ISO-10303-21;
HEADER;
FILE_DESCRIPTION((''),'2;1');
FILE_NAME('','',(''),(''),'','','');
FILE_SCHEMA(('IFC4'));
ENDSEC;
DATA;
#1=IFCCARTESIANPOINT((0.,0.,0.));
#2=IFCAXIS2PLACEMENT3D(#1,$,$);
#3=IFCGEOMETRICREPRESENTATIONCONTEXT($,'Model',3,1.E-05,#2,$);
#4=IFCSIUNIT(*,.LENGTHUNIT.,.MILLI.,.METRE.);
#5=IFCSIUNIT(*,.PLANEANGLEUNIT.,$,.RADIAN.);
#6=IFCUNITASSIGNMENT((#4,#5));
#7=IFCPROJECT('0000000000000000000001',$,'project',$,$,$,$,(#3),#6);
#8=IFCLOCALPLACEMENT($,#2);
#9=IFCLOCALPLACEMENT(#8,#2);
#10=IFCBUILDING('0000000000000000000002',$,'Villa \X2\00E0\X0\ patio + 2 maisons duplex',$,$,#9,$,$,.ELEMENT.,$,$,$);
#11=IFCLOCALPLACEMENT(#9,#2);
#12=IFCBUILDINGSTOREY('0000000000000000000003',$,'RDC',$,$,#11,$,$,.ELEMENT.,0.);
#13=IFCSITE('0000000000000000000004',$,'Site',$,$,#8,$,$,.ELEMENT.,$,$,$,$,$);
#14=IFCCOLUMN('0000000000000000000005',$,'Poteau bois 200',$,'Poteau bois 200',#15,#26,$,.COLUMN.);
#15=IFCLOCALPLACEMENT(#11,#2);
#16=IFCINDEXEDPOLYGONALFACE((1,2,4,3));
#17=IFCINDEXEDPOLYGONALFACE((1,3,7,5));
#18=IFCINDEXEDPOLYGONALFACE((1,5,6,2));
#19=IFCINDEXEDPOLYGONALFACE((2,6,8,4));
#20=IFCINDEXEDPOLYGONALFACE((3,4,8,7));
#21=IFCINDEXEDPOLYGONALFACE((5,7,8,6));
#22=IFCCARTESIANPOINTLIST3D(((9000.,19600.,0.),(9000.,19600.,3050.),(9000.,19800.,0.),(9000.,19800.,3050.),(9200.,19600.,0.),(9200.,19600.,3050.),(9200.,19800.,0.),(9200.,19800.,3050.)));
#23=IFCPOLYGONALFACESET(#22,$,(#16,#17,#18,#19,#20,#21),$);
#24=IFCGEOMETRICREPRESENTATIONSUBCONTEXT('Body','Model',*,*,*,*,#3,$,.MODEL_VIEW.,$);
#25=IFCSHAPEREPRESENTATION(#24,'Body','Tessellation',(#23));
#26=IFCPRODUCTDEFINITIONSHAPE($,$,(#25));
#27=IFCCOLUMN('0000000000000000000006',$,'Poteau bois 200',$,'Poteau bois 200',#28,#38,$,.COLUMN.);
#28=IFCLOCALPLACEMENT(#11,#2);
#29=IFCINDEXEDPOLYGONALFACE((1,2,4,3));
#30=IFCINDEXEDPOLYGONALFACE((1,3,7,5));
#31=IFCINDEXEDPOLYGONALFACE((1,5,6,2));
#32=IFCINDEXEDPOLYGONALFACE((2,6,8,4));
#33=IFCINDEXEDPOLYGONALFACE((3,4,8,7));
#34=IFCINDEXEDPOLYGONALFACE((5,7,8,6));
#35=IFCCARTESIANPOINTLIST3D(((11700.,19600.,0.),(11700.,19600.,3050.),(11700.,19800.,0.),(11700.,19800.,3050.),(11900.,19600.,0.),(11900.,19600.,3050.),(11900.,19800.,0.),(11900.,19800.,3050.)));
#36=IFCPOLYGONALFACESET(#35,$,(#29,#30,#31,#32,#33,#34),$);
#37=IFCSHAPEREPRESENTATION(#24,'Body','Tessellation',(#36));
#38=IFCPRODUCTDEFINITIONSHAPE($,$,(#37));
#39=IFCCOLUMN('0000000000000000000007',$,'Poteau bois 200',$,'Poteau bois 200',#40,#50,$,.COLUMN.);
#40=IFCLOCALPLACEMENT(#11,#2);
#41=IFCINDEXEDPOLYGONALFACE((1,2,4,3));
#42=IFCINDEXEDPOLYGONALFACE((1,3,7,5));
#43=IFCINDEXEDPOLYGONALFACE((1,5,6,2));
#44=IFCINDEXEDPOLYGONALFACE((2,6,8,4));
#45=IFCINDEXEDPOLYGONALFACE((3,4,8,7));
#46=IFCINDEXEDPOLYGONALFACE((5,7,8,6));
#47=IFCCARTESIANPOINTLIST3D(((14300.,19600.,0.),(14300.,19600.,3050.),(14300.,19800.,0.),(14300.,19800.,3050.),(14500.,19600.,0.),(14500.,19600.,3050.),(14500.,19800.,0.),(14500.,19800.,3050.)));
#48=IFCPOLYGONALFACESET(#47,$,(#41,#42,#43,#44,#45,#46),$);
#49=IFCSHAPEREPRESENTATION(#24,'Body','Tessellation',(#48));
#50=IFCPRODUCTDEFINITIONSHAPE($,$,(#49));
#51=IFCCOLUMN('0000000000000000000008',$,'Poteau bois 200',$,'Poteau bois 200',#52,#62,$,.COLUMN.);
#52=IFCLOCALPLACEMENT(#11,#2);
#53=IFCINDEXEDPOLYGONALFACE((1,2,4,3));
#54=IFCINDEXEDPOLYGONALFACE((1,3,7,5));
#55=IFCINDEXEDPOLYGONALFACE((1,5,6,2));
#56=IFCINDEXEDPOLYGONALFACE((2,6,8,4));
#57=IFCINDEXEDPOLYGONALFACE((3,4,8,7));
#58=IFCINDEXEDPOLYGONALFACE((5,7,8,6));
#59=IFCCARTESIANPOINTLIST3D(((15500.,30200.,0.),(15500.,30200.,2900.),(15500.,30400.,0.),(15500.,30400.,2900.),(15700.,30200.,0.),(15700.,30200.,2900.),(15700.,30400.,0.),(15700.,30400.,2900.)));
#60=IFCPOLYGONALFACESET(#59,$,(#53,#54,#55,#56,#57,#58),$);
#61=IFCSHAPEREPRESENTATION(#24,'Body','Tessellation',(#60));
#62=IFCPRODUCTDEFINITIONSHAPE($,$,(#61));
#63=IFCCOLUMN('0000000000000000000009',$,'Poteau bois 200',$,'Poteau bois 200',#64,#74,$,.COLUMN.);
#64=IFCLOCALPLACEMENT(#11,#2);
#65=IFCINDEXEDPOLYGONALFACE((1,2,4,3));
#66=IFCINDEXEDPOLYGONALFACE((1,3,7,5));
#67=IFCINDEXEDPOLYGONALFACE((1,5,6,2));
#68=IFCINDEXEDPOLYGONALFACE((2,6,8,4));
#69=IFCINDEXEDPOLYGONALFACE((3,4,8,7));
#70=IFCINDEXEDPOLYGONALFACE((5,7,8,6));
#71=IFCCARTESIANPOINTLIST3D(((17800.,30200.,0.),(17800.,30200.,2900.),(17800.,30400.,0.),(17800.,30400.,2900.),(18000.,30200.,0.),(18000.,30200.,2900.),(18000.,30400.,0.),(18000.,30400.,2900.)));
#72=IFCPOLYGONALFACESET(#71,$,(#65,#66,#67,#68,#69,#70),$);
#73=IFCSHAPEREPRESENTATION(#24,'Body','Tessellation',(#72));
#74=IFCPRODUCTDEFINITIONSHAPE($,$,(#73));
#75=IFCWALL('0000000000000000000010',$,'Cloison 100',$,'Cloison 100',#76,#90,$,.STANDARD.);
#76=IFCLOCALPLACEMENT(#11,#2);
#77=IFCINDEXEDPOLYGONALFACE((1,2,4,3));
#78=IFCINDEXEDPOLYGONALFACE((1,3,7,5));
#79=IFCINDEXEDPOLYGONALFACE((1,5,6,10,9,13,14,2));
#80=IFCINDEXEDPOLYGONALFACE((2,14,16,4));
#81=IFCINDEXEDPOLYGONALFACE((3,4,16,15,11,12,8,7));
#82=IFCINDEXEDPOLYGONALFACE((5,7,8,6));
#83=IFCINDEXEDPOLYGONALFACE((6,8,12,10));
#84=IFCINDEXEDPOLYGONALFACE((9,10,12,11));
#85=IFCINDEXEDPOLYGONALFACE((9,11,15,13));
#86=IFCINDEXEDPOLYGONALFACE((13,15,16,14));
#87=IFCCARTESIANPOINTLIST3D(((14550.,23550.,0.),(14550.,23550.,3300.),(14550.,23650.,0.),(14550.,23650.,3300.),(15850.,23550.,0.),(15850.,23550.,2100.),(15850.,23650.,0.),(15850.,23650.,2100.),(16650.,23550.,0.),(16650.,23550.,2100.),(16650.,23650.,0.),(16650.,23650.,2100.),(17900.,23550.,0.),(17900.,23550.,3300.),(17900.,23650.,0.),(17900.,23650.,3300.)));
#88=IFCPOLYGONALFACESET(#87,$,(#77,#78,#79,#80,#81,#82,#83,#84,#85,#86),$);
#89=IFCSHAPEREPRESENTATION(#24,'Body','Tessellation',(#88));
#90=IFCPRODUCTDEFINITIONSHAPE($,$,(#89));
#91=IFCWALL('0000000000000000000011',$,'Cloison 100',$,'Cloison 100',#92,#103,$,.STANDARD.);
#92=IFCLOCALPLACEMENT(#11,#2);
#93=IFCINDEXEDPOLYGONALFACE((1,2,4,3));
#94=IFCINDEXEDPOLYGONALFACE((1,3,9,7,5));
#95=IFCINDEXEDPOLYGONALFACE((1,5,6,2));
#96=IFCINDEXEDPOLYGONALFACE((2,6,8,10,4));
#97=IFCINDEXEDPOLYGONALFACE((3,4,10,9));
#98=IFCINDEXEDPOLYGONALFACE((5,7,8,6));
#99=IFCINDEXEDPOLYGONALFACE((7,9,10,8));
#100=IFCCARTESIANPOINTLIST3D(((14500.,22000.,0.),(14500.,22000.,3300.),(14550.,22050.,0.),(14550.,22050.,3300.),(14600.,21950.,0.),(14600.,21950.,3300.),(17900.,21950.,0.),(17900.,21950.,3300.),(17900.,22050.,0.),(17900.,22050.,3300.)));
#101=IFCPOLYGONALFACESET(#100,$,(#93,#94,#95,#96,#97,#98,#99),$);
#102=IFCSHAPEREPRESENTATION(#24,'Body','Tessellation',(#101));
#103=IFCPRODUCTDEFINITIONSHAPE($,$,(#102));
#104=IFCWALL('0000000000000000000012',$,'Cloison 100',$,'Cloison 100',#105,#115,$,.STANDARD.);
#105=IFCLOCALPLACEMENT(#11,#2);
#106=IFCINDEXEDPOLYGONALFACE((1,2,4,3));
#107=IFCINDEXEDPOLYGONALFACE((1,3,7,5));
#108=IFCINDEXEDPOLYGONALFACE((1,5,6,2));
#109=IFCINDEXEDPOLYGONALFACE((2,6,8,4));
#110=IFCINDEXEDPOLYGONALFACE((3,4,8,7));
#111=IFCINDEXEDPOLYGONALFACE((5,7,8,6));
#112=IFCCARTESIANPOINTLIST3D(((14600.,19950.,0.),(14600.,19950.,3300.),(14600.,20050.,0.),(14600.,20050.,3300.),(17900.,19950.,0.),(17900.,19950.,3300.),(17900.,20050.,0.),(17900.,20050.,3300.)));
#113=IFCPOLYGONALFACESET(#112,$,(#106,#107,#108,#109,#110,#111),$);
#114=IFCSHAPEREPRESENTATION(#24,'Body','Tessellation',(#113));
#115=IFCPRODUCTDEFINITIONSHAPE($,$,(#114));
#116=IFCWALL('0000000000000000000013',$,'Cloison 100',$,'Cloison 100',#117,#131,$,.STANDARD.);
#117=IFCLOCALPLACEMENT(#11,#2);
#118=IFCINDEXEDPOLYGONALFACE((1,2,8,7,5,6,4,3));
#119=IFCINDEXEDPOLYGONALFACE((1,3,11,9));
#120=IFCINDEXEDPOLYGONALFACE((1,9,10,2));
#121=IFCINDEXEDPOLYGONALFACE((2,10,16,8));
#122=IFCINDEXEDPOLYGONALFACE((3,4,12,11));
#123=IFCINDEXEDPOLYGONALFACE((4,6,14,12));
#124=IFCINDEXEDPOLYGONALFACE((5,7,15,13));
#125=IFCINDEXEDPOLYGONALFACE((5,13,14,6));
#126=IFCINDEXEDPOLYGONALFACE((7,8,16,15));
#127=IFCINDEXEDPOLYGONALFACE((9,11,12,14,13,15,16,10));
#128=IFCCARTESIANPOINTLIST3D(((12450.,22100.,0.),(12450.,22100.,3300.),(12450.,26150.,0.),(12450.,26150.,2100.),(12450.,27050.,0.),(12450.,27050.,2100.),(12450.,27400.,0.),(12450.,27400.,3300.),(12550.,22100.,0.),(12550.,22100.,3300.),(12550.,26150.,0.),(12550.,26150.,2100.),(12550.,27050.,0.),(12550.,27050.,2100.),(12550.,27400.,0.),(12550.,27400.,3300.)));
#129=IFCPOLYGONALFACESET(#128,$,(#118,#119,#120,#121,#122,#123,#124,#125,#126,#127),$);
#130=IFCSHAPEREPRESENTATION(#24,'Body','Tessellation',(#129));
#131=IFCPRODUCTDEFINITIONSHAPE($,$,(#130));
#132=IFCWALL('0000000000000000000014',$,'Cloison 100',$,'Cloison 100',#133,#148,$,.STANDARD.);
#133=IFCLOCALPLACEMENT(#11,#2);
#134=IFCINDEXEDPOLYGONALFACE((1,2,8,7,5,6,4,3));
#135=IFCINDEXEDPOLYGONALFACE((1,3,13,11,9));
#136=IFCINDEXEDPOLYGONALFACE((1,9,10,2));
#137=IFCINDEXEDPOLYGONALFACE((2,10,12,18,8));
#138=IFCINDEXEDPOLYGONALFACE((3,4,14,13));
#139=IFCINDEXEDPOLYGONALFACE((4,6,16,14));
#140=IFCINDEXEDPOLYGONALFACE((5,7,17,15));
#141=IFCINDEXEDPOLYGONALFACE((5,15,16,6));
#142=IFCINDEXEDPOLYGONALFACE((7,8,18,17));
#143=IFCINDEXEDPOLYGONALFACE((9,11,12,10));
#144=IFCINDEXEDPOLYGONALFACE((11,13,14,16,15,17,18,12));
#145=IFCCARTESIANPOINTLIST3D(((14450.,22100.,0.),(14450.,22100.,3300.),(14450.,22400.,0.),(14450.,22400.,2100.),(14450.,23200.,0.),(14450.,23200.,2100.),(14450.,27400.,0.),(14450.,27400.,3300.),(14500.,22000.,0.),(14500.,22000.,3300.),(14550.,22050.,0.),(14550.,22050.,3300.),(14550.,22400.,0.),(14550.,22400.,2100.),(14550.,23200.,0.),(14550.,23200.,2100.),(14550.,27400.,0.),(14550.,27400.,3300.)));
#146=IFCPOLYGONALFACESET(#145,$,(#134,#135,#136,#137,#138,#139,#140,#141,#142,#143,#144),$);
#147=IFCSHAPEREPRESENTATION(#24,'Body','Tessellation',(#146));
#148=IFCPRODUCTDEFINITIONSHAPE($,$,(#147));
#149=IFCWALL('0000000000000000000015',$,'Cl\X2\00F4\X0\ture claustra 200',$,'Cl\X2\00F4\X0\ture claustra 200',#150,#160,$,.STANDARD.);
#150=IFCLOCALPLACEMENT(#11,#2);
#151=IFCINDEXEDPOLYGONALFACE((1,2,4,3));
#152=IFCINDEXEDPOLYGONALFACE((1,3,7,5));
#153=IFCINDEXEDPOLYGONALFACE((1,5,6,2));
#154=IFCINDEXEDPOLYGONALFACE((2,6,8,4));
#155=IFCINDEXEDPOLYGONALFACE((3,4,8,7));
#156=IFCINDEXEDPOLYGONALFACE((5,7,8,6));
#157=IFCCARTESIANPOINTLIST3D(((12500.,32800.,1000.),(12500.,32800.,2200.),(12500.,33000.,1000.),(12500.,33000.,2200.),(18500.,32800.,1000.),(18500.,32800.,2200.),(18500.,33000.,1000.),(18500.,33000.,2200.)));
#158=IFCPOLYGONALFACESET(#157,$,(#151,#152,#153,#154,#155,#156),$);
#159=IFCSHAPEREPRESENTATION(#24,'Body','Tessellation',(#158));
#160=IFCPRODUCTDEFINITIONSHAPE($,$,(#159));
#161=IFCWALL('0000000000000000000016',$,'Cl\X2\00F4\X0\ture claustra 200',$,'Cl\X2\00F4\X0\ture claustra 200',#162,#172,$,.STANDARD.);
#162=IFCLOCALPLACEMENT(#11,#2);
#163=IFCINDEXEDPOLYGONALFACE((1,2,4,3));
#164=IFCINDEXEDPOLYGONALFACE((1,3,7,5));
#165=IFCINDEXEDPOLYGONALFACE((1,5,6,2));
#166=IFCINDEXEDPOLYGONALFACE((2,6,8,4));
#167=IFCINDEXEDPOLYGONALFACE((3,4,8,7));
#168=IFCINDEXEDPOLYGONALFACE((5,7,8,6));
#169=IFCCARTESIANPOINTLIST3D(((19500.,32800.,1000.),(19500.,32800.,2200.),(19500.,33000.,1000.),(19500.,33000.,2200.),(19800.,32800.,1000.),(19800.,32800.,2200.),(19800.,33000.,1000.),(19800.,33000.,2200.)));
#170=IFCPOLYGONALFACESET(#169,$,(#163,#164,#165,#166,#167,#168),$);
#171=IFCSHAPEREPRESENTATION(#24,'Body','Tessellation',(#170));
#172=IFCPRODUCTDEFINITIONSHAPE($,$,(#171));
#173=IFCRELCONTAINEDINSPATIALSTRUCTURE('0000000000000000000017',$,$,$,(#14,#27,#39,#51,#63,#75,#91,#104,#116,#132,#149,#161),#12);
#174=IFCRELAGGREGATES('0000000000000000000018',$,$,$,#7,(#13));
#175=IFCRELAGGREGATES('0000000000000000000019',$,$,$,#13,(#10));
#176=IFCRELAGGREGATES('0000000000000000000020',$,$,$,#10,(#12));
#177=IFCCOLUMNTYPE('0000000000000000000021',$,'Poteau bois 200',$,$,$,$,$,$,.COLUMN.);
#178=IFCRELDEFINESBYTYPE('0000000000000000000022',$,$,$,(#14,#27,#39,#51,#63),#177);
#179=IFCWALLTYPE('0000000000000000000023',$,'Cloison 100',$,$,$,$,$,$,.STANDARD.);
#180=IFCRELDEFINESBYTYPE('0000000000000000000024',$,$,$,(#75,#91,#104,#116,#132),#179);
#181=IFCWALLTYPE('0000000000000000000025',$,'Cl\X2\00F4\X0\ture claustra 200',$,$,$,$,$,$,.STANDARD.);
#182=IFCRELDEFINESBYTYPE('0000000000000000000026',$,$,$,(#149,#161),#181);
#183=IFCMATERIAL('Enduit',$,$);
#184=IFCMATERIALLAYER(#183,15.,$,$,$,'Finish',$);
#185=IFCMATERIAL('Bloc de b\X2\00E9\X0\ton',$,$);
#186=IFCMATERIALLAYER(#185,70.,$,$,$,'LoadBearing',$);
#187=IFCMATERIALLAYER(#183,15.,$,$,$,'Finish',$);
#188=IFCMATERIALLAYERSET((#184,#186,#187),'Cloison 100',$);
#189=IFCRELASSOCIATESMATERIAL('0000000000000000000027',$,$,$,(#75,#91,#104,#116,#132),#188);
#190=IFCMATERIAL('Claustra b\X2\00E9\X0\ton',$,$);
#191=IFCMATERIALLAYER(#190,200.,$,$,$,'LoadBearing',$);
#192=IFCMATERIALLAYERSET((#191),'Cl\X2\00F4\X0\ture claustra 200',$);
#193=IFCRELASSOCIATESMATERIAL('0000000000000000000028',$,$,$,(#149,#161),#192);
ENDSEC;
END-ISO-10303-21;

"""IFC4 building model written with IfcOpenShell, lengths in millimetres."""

from ifc_helpers import new_model, si_unit, frame, frame_2d, origin, origin_2d, place, context, subcontext, project, spatial, polyline, rectangle, outline, extrude, material, layer, layer_set, layer_usage, material_profile, profile_set, profile_usage, type_object, element, save


model = new_model("IFC4")

# Units and contexts
model_context = context("Model", 3, precision=1e-05, world=origin())
body_context = subcontext(model_context, "Body", "Model", "MODEL_VIEW")
ifc_project = project(units=[si_unit("LENGTHUNIT", "METRE", prefix="MILLI"), si_unit("PLANEANGLEUNIT", "RADIAN")], contexts=[model_context])

# Site, building, storey
site_placement = place(None, origin())
site = spatial("IfcSite", under=ifc_project, at=site_placement, Name="Site", CompositionType="ELEMENT")
building_placement = place(site_placement, origin())
building = spatial("IfcBuilding", under=site, at=building_placement, Name="Villa à patio + 2 maisons duplex", CompositionType="ELEMENT")
storey_placement = place(building_placement, origin())
storey = spatial("IfcBuildingStorey", under=building, at=storey_placement, Name="RDC", CompositionType="ELEMENT", Elevation=0.0)

# Columns
ifc_material_profile = material_profile(None, rectangle(XDim=200.0, YDim=200.0, at=origin_2d()), Name="Poteau bois 200")
ifc_profile_set = profile_set([ifc_material_profile], Name="Poteau bois 200")
ifc_profile_usage = profile_usage(ifc_profile_set, cardinal=5)
column_type = type_object("IfcColumnType", Name="Poteau bois 200", PredefinedType="COLUMN", material=ifc_profile_set)
for number, where, z_axis, x_axis, name in (
    (1, (9100.0, 19700.0, 0.0), (0.0, 0.0, 1.0), (1.0, 0.0, 0.0), "Poteau bois 200"),
    (2, (11800.0, 19700.0, 0.0), (0.0, 0.0, 1.0), (1.0, 0.0, 0.0), "Poteau bois 200"),
    (3, (14400.0, 19700.0, 0.0), (0.0, 0.0, 1.0), (1.0, 0.0, 0.0), "Poteau bois 200"),
):
    element("IfcColumn", number, at=place(storey_placement, frame(where, z_axis=z_axis, x_axis=x_axis)), inside=storey, type_object=column_type, material=ifc_profile_usage, Name=name, ObjectType="Poteau bois 200", PredefinedType="COLUMN", context=body_context, shape_type="SweptSolid", body=[
        extrude(rectangle(XDim=200.0, YDim=200.0, at=origin_2d()), origin(), (0.0, 0.0, 1.0), 3050.0),
    ])
for number, where, z_axis, x_axis, name in (
    (4, (15600.0, 30300.0, 0.0), (0.0, 0.0, 1.0), (1.0, 0.0, 0.0), "Poteau bois 200"),
    (5, (17900.0, 30300.0, 0.0), (0.0, 0.0, 1.0), (1.0, 0.0, 0.0), "Poteau bois 200"),
):
    element("IfcColumn", number, at=place(storey_placement, frame(where, z_axis=z_axis, x_axis=x_axis)), inside=storey, type_object=column_type, material=ifc_profile_usage, Name=name, ObjectType="Poteau bois 200", PredefinedType="COLUMN", context=body_context, shape_type="SweptSolid", body=[
        extrude(rectangle(XDim=200.0, YDim=200.0, at=origin_2d()), origin(), (0.0, 0.0, 1.0), 2900.0),
    ])

# Wall, opening
ifc_material_1 = material(Name="Enduit")
ifc_layer_1 = layer(ifc_material_1, 15.0, Category="Finish")
ifc_material_2 = material(Name="Bloc de béton")
ifc_layer_2 = layer(ifc_material_2, 70.0, Category="LoadBearing")
ifc_layer_3 = layer(ifc_material_1, 15.0, Category="Finish")
ifc_layer_set_1 = layer_set([ifc_layer_1, ifc_layer_2, ifc_layer_3], Name="Cloison 100")
ifc_layer_usage_1 = layer_usage(ifc_layer_set_1, "AXIS2", "NEGATIVE", 50.0)
wall_type_1 = type_object("IfcWallType", Name="Cloison 100", PredefinedType="STANDARD")
wall_1_placement = place(storey_placement, frame((14500.0, 23600.0, 0.0), z_axis=(0.0, 0.0, 1.0), x_axis=(1.0, 0.0, 0.0)))
wall_1 = element("IfcWall", 6, at=wall_1_placement, inside=storey, type_object=wall_type_1, material=ifc_layer_usage_1, Name="Cloison 100", ObjectType="Cloison 100", PredefinedType="STANDARD", context=body_context, shape_type="SweptSolid", body=[
    extrude(outline(polyline([(50.0, -50.0), (50.0, 50.0), (3400.0, 50.0), (3400.0, -50.0), (50.0, -50.0)])), origin(), (0.0, 0.0, 1.0), 3300.0),
])
opening_1_placement = place(wall_1_placement, frame((1350.0, 0.0, 0.0), z_axis=(0.0, 0.0, 1.0), x_axis=(1.0, 0.0, 0.0)))
element("IfcOpeningElement", 7, at=opening_1_placement, cuts=wall_1, PredefinedType="OPENING", context=body_context, shape_type="SweptSolid", body=[
    extrude(rectangle(XDim=800.0, YDim=120.0, at=frame_2d((400.0, 0.0))), origin(), (0.0, 0.0, 1.0), 2100.0),
])

# Walls
wall_2_placement = place(storey_placement, frame((14500.0, 22000.0, 0.0), z_axis=(0.0, 0.0, 1.0), x_axis=(1.0, 0.0, 0.0)))
element("IfcWall", 8, at=wall_2_placement, inside=storey, type_object=wall_type_1, material=ifc_layer_usage_1, Name="Cloison 100", ObjectType="Cloison 100", PredefinedType="STANDARD", context=body_context, shape_type="SweptSolid", body=[
    extrude(outline(polyline([(100.0, -50.0), (0.0, 0.0), (50.0, 50.0), (3400.0, 50.0), (3400.0, -50.0), (100.0, -50.0)])), origin(), (0.0, 0.0, 1.0), 3300.0),
])
wall_3_placement = place(storey_placement, frame((14500.0, 20000.0, 0.0), z_axis=(0.0, 0.0, 1.0), x_axis=(1.0, 0.0, 0.0)))
element("IfcWall", 9, at=wall_3_placement, inside=storey, type_object=wall_type_1, material=ifc_layer_usage_1, Name="Cloison 100", ObjectType="Cloison 100", PredefinedType="STANDARD", context=body_context, shape_type="SweptSolid", body=[
    extrude(outline(polyline([(100.0, -50.0), (100.0, 50.0), (3400.0, 50.0), (3400.0, -50.0), (100.0, -50.0)])), origin(), (0.0, 0.0, 1.0), 3300.0),
])

# Walls, openings
wall_4_placement = place(storey_placement, frame((12500.0, 27500.0, 0.0), z_axis=(0.0, 0.0, 1.0), x_axis=(0.0, -1.0, 0.0)))
wall_4 = element("IfcWall", 10, at=wall_4_placement, inside=storey, type_object=wall_type_1, material=ifc_layer_usage_1, Name="Cloison 100", ObjectType="Cloison 100", PredefinedType="STANDARD", context=body_context, shape_type="SweptSolid", body=[
    extrude(outline(polyline([(100.0, -50.0), (100.0, 50.0), (5400.0, 50.0), (5400.0, -50.0), (100.0, -50.0)])), origin(), (0.0, 0.0, 1.0), 3300.0),
])
opening_2_placement = place(wall_4_placement, frame((450.0, 0.0, 0.0), z_axis=(0.0, 0.0, 1.0), x_axis=(1.0, 0.0, 0.0)))
element("IfcOpeningElement", 11, at=opening_2_placement, cuts=wall_4, PredefinedType="OPENING", context=body_context, shape_type="SweptSolid", body=[
    extrude(rectangle(XDim=900.0, YDim=120.0, at=frame_2d((450.0, 0.0))), origin(), (0.0, 0.0, 1.0), 2100.0),
])
wall_5_placement = place(storey_placement, frame((14500.0, 27500.0, 0.0), z_axis=(0.0, 0.0, 1.0), x_axis=(0.0, -1.0, 0.0)))
wall_5 = element("IfcWall", 12, at=wall_5_placement, inside=storey, type_object=wall_type_1, material=ifc_layer_usage_1, Name="Cloison 100", ObjectType="Cloison 100", PredefinedType="STANDARD", context=body_context, shape_type="SweptSolid", body=[
    extrude(outline(polyline([(100.0, -50.0), (100.0, 50.0), (5450.0, 50.0), (5500.0, 0.0), (5400.0, -50.0), (100.0, -50.0)])), origin(), (0.0, 0.0, 1.0), 3300.0),
])
opening_3_placement = place(wall_5_placement, frame((4300.0, 0.0, 0.0), z_axis=(0.0, 0.0, 1.0), x_axis=(1.0, 0.0, 0.0)))
element("IfcOpeningElement", 13, at=opening_3_placement, cuts=wall_5, PredefinedType="OPENING", context=body_context, shape_type="SweptSolid", body=[
    extrude(rectangle(XDim=800.0, YDim=120.0, at=frame_2d((400.0, 0.0))), origin(), (0.0, 0.0, 1.0), 2100.0),
])

# Walls
ifc_material_3 = material(Name="Claustra béton")
ifc_layer_4 = layer(ifc_material_3, 200.0, Category="LoadBearing")
ifc_layer_set_2 = layer_set([ifc_layer_4], Name="Clôture claustra 200")
ifc_layer_usage_2 = layer_usage(ifc_layer_set_2, "AXIS2", "NEGATIVE", 100.0)
wall_type_2 = type_object("IfcWallType", Name="Clôture claustra 200", PredefinedType="STANDARD")
wall_6_placement = place(storey_placement, frame((12500.0, 32900.0, 1000.0), z_axis=(0.0, 0.0, 1.0), x_axis=(1.0, 0.0, 0.0)))
element("IfcWall", 14, at=wall_6_placement, inside=storey, type_object=wall_type_2, material=ifc_layer_usage_2, Name="Clôture claustra 200", ObjectType="Clôture claustra 200", PredefinedType="STANDARD", context=body_context, shape_type="SweptSolid", body=[
    extrude(outline(polyline([(0.0, -100.0), (0.0, 100.0), (6000.0, 100.0), (6000.0, -100.0), (0.0, -100.0)])), origin(), (0.0, 0.0, 1.0), 1200.0),
])
wall_7_placement = place(storey_placement, frame((19500.0, 32900.0, 1000.0), z_axis=(0.0, 0.0, 1.0), x_axis=(1.0, 0.0, 0.0)))
element("IfcWall", 15, at=wall_7_placement, inside=storey, type_object=wall_type_2, material=ifc_layer_usage_2, Name="Clôture claustra 200", ObjectType="Clôture claustra 200", PredefinedType="STANDARD", context=body_context, shape_type="SweptSolid", body=[
    extrude(outline(polyline([(0.0, -100.0), (0.0, 100.0), (300.0, 100.0), (300.0, -100.0), (0.0, -100.0)])), origin(), (0.0, 0.0, 1.0), 1200.0),
])

save(model, "model.ifc")
